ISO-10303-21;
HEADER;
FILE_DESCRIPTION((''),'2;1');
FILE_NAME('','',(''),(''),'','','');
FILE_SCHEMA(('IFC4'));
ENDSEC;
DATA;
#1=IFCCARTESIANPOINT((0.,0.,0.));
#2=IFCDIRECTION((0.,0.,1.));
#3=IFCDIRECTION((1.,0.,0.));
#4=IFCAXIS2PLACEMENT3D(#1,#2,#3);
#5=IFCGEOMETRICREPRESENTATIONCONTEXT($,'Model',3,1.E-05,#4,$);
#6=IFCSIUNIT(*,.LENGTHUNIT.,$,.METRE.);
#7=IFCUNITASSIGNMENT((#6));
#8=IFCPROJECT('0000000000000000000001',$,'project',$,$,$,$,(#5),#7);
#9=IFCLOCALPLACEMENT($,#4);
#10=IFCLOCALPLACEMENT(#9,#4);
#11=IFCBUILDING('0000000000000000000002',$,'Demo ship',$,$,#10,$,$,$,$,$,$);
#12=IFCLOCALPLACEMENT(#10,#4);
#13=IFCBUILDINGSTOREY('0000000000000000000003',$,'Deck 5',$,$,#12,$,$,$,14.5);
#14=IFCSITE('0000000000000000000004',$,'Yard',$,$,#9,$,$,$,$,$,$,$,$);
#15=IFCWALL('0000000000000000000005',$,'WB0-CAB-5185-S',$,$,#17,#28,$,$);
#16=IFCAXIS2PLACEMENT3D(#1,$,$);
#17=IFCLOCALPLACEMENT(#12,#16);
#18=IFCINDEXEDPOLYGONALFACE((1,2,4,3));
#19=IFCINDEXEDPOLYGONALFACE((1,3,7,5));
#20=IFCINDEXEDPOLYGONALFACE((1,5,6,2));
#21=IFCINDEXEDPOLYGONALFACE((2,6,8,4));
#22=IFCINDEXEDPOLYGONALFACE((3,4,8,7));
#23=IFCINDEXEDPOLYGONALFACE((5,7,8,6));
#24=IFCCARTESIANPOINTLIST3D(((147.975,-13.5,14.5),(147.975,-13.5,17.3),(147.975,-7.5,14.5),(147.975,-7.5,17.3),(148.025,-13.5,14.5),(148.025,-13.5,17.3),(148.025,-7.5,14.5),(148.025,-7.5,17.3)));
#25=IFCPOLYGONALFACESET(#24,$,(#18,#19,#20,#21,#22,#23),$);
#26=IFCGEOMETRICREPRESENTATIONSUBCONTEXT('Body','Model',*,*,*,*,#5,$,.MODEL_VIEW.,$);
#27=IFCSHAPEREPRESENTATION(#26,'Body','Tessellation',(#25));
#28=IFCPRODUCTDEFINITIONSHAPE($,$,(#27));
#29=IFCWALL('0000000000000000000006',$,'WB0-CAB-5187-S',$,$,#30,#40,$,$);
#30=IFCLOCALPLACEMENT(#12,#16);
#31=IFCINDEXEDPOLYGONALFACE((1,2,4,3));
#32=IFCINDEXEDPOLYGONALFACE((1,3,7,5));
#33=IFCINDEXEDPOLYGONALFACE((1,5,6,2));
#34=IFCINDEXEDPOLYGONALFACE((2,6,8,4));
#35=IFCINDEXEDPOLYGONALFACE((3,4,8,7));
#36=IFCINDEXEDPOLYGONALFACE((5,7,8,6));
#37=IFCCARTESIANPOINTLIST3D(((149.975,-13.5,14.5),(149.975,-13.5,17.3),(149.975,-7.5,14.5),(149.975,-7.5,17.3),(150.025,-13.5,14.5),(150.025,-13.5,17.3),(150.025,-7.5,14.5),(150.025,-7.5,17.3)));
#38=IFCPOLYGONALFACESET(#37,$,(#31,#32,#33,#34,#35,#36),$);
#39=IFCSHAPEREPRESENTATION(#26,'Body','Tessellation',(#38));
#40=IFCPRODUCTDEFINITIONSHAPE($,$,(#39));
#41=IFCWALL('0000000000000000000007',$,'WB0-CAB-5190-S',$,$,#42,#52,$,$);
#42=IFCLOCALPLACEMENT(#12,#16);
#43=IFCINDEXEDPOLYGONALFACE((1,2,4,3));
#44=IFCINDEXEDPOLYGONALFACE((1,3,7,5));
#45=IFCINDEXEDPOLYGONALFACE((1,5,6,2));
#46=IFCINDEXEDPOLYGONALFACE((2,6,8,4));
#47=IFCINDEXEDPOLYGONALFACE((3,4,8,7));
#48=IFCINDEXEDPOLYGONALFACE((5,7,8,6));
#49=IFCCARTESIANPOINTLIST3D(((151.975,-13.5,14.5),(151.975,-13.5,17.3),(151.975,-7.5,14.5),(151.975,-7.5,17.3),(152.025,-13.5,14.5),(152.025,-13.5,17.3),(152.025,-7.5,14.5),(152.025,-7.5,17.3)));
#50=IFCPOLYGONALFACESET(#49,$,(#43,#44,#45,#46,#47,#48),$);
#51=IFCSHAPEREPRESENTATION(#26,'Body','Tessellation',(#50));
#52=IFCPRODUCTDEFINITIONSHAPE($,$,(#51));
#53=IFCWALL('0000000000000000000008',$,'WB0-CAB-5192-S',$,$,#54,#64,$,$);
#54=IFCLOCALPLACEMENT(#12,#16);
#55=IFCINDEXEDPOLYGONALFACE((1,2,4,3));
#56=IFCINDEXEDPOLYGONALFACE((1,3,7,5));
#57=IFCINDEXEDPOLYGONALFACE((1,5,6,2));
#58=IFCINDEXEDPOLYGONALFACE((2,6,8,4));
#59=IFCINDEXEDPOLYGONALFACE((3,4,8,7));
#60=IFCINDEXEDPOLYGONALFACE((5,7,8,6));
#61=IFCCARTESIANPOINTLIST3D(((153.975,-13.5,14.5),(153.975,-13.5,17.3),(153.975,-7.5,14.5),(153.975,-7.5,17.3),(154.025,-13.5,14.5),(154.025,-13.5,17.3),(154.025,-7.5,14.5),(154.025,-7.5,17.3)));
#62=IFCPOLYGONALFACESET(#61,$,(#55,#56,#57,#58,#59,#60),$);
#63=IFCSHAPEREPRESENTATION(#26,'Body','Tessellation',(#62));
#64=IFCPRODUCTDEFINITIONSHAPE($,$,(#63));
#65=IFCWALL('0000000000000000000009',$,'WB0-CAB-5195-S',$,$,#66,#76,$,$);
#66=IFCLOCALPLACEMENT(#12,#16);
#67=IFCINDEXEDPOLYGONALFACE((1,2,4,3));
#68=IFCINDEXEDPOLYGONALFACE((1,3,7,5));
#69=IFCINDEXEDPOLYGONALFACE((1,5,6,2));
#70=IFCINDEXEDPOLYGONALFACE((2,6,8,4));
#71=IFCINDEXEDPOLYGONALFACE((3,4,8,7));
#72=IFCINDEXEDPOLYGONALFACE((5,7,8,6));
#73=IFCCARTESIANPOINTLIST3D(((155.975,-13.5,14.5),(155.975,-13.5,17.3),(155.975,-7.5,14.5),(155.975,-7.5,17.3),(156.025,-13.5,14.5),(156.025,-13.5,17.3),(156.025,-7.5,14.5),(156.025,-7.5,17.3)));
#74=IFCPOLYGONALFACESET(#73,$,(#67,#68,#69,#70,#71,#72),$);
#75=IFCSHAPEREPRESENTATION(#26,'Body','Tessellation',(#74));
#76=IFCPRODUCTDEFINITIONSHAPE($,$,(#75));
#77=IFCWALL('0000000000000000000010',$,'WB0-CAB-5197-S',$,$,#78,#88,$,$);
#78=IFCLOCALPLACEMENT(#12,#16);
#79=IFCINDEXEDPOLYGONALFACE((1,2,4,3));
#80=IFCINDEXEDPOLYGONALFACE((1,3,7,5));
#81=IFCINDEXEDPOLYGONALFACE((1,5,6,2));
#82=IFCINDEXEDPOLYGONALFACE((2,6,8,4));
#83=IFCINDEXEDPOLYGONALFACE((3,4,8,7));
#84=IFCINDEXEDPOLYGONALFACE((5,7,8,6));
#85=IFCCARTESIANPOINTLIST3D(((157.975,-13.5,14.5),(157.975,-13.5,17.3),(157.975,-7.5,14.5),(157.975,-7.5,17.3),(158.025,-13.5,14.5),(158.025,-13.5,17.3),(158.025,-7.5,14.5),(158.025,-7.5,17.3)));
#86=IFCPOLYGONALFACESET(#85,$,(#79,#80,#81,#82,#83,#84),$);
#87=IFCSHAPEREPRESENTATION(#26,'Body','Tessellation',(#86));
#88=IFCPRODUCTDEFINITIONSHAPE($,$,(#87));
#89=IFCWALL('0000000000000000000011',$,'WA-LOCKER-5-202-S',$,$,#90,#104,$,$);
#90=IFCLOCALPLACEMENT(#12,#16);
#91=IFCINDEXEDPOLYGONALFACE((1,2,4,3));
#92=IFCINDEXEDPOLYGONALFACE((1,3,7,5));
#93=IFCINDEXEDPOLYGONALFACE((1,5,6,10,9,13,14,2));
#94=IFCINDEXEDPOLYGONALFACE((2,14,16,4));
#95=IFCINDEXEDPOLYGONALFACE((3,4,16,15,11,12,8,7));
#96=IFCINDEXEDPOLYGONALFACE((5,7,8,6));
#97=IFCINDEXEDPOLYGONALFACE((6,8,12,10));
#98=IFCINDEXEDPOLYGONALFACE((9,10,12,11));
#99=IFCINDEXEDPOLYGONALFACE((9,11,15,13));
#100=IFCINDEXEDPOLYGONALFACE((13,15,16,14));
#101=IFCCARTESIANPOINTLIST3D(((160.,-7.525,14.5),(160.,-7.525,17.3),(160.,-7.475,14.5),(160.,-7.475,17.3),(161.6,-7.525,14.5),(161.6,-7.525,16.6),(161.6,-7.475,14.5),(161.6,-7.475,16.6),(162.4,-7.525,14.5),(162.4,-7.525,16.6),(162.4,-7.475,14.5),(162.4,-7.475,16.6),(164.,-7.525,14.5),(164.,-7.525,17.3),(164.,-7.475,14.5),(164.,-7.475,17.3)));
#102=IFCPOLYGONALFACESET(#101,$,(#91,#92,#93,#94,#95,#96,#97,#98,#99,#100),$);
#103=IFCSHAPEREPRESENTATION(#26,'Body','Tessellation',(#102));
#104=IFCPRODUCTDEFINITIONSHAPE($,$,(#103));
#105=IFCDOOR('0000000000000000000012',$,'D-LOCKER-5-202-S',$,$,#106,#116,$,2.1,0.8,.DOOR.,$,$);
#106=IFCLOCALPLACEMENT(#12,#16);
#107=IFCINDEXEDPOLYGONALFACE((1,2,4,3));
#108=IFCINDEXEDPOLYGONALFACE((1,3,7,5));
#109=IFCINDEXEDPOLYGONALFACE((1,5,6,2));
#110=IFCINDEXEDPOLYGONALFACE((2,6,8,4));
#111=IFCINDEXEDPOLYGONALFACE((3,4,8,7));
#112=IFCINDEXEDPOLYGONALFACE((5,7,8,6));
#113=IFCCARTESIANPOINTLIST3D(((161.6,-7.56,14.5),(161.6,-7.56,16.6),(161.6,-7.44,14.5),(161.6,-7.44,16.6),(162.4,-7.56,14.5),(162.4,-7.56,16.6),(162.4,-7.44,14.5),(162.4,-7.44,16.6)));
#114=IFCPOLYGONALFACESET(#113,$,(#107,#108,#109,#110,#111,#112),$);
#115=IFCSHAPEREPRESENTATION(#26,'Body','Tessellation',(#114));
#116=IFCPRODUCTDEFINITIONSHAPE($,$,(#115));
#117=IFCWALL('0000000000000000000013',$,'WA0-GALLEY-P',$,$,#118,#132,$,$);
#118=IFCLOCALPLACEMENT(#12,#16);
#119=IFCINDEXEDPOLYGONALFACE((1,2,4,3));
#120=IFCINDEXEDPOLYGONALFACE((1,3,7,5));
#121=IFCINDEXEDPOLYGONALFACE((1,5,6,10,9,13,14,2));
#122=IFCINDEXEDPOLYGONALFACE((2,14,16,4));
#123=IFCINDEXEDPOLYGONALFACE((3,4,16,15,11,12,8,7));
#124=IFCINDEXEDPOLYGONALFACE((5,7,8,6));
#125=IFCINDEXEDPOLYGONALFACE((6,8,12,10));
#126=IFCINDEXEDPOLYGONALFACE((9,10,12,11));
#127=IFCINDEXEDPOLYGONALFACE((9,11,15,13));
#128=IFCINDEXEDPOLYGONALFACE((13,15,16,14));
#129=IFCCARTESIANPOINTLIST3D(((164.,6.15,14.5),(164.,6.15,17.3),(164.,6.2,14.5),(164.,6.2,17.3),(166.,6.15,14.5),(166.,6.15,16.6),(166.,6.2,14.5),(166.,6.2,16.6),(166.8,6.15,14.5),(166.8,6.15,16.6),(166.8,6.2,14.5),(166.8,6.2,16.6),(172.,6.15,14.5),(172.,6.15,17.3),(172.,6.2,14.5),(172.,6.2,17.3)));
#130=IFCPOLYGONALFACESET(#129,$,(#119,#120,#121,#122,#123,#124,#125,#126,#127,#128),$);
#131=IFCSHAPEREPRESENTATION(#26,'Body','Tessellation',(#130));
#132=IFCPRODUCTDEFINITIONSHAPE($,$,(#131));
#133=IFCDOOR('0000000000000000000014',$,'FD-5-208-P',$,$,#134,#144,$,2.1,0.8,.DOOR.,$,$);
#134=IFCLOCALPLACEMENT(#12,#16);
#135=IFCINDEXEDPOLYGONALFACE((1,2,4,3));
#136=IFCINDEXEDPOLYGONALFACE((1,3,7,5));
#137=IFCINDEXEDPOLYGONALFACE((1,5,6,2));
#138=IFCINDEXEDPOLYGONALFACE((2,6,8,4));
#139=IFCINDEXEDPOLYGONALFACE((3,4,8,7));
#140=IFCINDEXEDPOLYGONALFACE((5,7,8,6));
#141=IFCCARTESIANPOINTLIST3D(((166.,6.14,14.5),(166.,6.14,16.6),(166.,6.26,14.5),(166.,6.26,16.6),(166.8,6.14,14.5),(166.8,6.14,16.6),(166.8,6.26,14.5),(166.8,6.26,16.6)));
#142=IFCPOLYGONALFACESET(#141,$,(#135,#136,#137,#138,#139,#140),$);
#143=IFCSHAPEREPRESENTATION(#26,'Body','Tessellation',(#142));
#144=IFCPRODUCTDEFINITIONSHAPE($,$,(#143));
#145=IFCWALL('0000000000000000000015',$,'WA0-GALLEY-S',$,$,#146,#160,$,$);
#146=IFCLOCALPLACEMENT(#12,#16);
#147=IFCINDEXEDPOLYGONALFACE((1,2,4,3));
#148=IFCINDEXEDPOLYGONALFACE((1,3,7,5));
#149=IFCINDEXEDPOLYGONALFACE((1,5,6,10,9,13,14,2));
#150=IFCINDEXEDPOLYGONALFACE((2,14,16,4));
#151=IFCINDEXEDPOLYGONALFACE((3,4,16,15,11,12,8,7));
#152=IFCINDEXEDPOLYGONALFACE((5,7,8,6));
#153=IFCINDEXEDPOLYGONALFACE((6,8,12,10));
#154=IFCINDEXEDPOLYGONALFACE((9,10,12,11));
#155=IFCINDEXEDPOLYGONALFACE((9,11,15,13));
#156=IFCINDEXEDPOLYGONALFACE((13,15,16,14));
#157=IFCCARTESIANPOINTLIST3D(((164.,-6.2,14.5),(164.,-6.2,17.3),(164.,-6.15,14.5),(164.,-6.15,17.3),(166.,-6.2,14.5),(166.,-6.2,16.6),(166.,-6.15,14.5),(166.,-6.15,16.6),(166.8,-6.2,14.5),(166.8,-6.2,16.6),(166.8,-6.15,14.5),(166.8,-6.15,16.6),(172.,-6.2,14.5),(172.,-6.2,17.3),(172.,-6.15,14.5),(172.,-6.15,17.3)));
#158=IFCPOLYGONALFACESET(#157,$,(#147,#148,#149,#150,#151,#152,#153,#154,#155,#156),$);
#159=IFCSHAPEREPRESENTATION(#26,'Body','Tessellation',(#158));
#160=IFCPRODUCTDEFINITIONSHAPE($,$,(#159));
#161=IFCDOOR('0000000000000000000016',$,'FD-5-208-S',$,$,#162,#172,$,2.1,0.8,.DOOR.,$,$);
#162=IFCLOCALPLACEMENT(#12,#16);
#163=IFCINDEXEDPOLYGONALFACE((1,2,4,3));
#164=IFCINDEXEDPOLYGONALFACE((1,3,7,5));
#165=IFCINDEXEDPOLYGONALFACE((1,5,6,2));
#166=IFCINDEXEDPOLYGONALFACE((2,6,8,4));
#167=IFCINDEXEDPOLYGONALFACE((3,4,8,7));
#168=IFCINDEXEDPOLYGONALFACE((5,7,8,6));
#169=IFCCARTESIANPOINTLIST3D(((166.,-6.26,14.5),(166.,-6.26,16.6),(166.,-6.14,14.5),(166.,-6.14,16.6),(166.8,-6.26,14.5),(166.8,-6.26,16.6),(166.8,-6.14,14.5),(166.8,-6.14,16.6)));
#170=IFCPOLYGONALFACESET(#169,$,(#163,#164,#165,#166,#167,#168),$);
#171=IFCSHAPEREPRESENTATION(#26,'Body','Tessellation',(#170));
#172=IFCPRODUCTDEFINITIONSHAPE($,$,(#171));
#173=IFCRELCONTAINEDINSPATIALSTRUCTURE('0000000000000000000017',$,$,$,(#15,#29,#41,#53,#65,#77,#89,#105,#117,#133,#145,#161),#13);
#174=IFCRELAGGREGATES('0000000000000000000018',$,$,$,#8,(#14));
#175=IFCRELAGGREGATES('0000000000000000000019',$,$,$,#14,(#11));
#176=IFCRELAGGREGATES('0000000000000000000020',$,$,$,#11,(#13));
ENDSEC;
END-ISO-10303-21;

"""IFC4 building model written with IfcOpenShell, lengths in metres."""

from ifc_helpers import new_model, si_unit, frame, frame_2d, origin, origin_with_axes, place, context, subcontext, project, spatial, rectangle, extrude, element, fill, save


model = new_model("IFC4")

# Units and contexts
model_context = context("Model", 3, precision=1e-05, world=origin_with_axes())
body_context = subcontext(model_context, "Body", "Model", "MODEL_VIEW")
ifc_project = project(units=[si_unit("LENGTHUNIT", "METRE")], contexts=[model_context])

# Site, building, storey
site_placement = place(None, origin_with_axes())
site = spatial("IfcSite", under=ifc_project, at=site_placement, Name="Yard")
building_placement = place(site_placement, origin_with_axes())
building = spatial("IfcBuilding", under=site, at=building_placement, Name="Demo ship")
storey_placement = place(building_placement, origin_with_axes())
storey = spatial("IfcBuildingStorey", under=building, at=storey_placement, Name="Deck 5", Elevation=14.5)

# Walls
for number, where, z_axis, x_axis, name in (
    (1, (147.975, -13.5, 14.5), (0.0, 0.0, 1.0), (1.0, 0.0, 0.0), "WB0-CAB-5185-S"),
    (2, (149.975, -13.5, 14.5), (0.0, 0.0, 1.0), (1.0, 0.0, 0.0), "WB0-CAB-5187-S"),
    (3, (151.975, -13.5, 14.5), (0.0, 0.0, 1.0), (1.0, 0.0, 0.0), "WB0-CAB-5190-S"),
    (4, (153.975, -13.5, 14.5), (0.0, 0.0, 1.0), (1.0, 0.0, 0.0), "WB0-CAB-5192-S"),
    (5, (155.975, -13.5, 14.5), (0.0, 0.0, 1.0), (1.0, 0.0, 0.0), "WB0-CAB-5195-S"),
    (6, (157.975, -13.5, 14.5), (0.0, 0.0, 1.0), (1.0, 0.0, 0.0), "WB0-CAB-5197-S"),
):
    element("IfcWall", number, at=place(storey_placement, frame(where, z_axis=z_axis, x_axis=x_axis)), inside=storey, Name=name, context=body_context, shape_type="SweptSolid", body=[
        extrude(rectangle(XDim=0.05, YDim=6.0, at=frame_2d((0.025, 3.0))), origin(), (0.0, 0.0, 1.0), 2.8),
    ])

# Walls, openings, doors
wall_1_placement = place(storey_placement, frame((160.0, -7.525, 14.5), z_axis=(0.0, 0.0, 1.0), x_axis=(1.0, 0.0, 0.0)))
wall_1 = element("IfcWall", 7, at=wall_1_placement, inside=storey, Name="WA-LOCKER-5-202-S", context=body_context, shape_type="SweptSolid", body=[
    extrude(rectangle(XDim=4.0, YDim=0.05, at=frame_2d((2.0, 0.025))), origin(), (0.0, 0.0, 1.0), 2.8),
])
opening_1_placement = place(None, frame((161.6, -7.56, 14.5), z_axis=(0.0, 0.0, 1.0), x_axis=(1.0, 0.0, 0.0)))
opening_1 = element("IfcOpeningElement", 8, at=opening_1_placement, cuts=wall_1, context=body_context, shape_type="SweptSolid", body=[
    extrude(rectangle(XDim=0.8, YDim=0.12, at=frame_2d((0.4, 0.06))), origin(), (0.0, 0.0, 1.0), 2.1),
])
door_1_placement = place(storey_placement, frame((161.6, -7.56, 14.5), z_axis=(0.0, 0.0, 1.0), x_axis=(1.0, 0.0, 0.0)))
door_1 = element("IfcDoor", 9, at=door_1_placement, inside=storey, Name="D-LOCKER-5-202-S", OverallHeight=2.1, OverallWidth=0.8, PredefinedType="DOOR", context=body_context, shape_type="SweptSolid", body=[
    extrude(rectangle(XDim=0.8, YDim=0.12, at=frame_2d((0.4, 0.06))), origin(), (0.0, 0.0, 1.0), 2.1),
])
fill(opening_1, door_1)
wall_2_placement = place(storey_placement, frame((164.0, 6.15, 14.5), z_axis=(0.0, 0.0, 1.0), x_axis=(1.0, 0.0, 0.0)))
wall_2 = element("IfcWall", 10, at=wall_2_placement, inside=storey, Name="WA0-GALLEY-P", context=body_context, shape_type="SweptSolid", body=[
    extrude(rectangle(XDim=8.0, YDim=0.05, at=frame_2d((4.0, 0.025))), origin(), (0.0, 0.0, 1.0), 2.8),
])
opening_2_placement = place(None, frame((166.0, 6.14, 14.5), z_axis=(0.0, 0.0, 1.0), x_axis=(1.0, 0.0, 0.0)))
opening_2 = element("IfcOpeningElement", 11, at=opening_2_placement, cuts=wall_2, context=body_context, shape_type="SweptSolid", body=[
    extrude(rectangle(XDim=0.8, YDim=0.12, at=frame_2d((0.4, 0.06))), origin(), (0.0, 0.0, 1.0), 2.1),
])
door_2_placement = place(storey_placement, frame((166.0, 6.14, 14.5), z_axis=(0.0, 0.0, 1.0), x_axis=(1.0, 0.0, 0.0)))
door_2 = element("IfcDoor", 12, at=door_2_placement, inside=storey, Name="FD-5-208-P", OverallHeight=2.1, OverallWidth=0.8, PredefinedType="DOOR", context=body_context, shape_type="SweptSolid", body=[
    extrude(rectangle(XDim=0.8, YDim=0.12, at=frame_2d((0.4, 0.06))), origin(), (0.0, 0.0, 1.0), 2.1),
])
fill(opening_2, door_2)
wall_3_placement = place(storey_placement, frame((164.0, -6.2, 14.5), z_axis=(0.0, 0.0, 1.0), x_axis=(1.0, 0.0, 0.0)))
wall_3 = element("IfcWall", 13, at=wall_3_placement, inside=storey, Name="WA0-GALLEY-S", context=body_context, shape_type="SweptSolid", body=[
    extrude(rectangle(XDim=8.0, YDim=0.05, at=frame_2d((4.0, 0.025))), origin(), (0.0, 0.0, 1.0), 2.8),
])
opening_3_placement = place(None, frame((166.0, -6.26, 14.5), z_axis=(0.0, 0.0, 1.0), x_axis=(1.0, 0.0, 0.0)))
opening_3 = element("IfcOpeningElement", 14, at=opening_3_placement, cuts=wall_3, context=body_context, shape_type="SweptSolid", body=[
    extrude(rectangle(XDim=0.8, YDim=0.12, at=frame_2d((0.4, 0.06))), origin(), (0.0, 0.0, 1.0), 2.1),
])
door_3_placement = place(storey_placement, frame((166.0, -6.26, 14.5), z_axis=(0.0, 0.0, 1.0), x_axis=(1.0, 0.0, 0.0)))
door_3 = element("IfcDoor", 15, at=door_3_placement, inside=storey, Name="FD-5-208-S", OverallHeight=2.1, OverallWidth=0.8, PredefinedType="DOOR", context=body_context, shape_type="SweptSolid", body=[
    extrude(rectangle(XDim=0.8, YDim=0.12, at=frame_2d((0.4, 0.06))), origin(), (0.0, 0.0, 1.0), 2.1),
])
fill(opening_3, door_3)

save(model, "model.ifc")
